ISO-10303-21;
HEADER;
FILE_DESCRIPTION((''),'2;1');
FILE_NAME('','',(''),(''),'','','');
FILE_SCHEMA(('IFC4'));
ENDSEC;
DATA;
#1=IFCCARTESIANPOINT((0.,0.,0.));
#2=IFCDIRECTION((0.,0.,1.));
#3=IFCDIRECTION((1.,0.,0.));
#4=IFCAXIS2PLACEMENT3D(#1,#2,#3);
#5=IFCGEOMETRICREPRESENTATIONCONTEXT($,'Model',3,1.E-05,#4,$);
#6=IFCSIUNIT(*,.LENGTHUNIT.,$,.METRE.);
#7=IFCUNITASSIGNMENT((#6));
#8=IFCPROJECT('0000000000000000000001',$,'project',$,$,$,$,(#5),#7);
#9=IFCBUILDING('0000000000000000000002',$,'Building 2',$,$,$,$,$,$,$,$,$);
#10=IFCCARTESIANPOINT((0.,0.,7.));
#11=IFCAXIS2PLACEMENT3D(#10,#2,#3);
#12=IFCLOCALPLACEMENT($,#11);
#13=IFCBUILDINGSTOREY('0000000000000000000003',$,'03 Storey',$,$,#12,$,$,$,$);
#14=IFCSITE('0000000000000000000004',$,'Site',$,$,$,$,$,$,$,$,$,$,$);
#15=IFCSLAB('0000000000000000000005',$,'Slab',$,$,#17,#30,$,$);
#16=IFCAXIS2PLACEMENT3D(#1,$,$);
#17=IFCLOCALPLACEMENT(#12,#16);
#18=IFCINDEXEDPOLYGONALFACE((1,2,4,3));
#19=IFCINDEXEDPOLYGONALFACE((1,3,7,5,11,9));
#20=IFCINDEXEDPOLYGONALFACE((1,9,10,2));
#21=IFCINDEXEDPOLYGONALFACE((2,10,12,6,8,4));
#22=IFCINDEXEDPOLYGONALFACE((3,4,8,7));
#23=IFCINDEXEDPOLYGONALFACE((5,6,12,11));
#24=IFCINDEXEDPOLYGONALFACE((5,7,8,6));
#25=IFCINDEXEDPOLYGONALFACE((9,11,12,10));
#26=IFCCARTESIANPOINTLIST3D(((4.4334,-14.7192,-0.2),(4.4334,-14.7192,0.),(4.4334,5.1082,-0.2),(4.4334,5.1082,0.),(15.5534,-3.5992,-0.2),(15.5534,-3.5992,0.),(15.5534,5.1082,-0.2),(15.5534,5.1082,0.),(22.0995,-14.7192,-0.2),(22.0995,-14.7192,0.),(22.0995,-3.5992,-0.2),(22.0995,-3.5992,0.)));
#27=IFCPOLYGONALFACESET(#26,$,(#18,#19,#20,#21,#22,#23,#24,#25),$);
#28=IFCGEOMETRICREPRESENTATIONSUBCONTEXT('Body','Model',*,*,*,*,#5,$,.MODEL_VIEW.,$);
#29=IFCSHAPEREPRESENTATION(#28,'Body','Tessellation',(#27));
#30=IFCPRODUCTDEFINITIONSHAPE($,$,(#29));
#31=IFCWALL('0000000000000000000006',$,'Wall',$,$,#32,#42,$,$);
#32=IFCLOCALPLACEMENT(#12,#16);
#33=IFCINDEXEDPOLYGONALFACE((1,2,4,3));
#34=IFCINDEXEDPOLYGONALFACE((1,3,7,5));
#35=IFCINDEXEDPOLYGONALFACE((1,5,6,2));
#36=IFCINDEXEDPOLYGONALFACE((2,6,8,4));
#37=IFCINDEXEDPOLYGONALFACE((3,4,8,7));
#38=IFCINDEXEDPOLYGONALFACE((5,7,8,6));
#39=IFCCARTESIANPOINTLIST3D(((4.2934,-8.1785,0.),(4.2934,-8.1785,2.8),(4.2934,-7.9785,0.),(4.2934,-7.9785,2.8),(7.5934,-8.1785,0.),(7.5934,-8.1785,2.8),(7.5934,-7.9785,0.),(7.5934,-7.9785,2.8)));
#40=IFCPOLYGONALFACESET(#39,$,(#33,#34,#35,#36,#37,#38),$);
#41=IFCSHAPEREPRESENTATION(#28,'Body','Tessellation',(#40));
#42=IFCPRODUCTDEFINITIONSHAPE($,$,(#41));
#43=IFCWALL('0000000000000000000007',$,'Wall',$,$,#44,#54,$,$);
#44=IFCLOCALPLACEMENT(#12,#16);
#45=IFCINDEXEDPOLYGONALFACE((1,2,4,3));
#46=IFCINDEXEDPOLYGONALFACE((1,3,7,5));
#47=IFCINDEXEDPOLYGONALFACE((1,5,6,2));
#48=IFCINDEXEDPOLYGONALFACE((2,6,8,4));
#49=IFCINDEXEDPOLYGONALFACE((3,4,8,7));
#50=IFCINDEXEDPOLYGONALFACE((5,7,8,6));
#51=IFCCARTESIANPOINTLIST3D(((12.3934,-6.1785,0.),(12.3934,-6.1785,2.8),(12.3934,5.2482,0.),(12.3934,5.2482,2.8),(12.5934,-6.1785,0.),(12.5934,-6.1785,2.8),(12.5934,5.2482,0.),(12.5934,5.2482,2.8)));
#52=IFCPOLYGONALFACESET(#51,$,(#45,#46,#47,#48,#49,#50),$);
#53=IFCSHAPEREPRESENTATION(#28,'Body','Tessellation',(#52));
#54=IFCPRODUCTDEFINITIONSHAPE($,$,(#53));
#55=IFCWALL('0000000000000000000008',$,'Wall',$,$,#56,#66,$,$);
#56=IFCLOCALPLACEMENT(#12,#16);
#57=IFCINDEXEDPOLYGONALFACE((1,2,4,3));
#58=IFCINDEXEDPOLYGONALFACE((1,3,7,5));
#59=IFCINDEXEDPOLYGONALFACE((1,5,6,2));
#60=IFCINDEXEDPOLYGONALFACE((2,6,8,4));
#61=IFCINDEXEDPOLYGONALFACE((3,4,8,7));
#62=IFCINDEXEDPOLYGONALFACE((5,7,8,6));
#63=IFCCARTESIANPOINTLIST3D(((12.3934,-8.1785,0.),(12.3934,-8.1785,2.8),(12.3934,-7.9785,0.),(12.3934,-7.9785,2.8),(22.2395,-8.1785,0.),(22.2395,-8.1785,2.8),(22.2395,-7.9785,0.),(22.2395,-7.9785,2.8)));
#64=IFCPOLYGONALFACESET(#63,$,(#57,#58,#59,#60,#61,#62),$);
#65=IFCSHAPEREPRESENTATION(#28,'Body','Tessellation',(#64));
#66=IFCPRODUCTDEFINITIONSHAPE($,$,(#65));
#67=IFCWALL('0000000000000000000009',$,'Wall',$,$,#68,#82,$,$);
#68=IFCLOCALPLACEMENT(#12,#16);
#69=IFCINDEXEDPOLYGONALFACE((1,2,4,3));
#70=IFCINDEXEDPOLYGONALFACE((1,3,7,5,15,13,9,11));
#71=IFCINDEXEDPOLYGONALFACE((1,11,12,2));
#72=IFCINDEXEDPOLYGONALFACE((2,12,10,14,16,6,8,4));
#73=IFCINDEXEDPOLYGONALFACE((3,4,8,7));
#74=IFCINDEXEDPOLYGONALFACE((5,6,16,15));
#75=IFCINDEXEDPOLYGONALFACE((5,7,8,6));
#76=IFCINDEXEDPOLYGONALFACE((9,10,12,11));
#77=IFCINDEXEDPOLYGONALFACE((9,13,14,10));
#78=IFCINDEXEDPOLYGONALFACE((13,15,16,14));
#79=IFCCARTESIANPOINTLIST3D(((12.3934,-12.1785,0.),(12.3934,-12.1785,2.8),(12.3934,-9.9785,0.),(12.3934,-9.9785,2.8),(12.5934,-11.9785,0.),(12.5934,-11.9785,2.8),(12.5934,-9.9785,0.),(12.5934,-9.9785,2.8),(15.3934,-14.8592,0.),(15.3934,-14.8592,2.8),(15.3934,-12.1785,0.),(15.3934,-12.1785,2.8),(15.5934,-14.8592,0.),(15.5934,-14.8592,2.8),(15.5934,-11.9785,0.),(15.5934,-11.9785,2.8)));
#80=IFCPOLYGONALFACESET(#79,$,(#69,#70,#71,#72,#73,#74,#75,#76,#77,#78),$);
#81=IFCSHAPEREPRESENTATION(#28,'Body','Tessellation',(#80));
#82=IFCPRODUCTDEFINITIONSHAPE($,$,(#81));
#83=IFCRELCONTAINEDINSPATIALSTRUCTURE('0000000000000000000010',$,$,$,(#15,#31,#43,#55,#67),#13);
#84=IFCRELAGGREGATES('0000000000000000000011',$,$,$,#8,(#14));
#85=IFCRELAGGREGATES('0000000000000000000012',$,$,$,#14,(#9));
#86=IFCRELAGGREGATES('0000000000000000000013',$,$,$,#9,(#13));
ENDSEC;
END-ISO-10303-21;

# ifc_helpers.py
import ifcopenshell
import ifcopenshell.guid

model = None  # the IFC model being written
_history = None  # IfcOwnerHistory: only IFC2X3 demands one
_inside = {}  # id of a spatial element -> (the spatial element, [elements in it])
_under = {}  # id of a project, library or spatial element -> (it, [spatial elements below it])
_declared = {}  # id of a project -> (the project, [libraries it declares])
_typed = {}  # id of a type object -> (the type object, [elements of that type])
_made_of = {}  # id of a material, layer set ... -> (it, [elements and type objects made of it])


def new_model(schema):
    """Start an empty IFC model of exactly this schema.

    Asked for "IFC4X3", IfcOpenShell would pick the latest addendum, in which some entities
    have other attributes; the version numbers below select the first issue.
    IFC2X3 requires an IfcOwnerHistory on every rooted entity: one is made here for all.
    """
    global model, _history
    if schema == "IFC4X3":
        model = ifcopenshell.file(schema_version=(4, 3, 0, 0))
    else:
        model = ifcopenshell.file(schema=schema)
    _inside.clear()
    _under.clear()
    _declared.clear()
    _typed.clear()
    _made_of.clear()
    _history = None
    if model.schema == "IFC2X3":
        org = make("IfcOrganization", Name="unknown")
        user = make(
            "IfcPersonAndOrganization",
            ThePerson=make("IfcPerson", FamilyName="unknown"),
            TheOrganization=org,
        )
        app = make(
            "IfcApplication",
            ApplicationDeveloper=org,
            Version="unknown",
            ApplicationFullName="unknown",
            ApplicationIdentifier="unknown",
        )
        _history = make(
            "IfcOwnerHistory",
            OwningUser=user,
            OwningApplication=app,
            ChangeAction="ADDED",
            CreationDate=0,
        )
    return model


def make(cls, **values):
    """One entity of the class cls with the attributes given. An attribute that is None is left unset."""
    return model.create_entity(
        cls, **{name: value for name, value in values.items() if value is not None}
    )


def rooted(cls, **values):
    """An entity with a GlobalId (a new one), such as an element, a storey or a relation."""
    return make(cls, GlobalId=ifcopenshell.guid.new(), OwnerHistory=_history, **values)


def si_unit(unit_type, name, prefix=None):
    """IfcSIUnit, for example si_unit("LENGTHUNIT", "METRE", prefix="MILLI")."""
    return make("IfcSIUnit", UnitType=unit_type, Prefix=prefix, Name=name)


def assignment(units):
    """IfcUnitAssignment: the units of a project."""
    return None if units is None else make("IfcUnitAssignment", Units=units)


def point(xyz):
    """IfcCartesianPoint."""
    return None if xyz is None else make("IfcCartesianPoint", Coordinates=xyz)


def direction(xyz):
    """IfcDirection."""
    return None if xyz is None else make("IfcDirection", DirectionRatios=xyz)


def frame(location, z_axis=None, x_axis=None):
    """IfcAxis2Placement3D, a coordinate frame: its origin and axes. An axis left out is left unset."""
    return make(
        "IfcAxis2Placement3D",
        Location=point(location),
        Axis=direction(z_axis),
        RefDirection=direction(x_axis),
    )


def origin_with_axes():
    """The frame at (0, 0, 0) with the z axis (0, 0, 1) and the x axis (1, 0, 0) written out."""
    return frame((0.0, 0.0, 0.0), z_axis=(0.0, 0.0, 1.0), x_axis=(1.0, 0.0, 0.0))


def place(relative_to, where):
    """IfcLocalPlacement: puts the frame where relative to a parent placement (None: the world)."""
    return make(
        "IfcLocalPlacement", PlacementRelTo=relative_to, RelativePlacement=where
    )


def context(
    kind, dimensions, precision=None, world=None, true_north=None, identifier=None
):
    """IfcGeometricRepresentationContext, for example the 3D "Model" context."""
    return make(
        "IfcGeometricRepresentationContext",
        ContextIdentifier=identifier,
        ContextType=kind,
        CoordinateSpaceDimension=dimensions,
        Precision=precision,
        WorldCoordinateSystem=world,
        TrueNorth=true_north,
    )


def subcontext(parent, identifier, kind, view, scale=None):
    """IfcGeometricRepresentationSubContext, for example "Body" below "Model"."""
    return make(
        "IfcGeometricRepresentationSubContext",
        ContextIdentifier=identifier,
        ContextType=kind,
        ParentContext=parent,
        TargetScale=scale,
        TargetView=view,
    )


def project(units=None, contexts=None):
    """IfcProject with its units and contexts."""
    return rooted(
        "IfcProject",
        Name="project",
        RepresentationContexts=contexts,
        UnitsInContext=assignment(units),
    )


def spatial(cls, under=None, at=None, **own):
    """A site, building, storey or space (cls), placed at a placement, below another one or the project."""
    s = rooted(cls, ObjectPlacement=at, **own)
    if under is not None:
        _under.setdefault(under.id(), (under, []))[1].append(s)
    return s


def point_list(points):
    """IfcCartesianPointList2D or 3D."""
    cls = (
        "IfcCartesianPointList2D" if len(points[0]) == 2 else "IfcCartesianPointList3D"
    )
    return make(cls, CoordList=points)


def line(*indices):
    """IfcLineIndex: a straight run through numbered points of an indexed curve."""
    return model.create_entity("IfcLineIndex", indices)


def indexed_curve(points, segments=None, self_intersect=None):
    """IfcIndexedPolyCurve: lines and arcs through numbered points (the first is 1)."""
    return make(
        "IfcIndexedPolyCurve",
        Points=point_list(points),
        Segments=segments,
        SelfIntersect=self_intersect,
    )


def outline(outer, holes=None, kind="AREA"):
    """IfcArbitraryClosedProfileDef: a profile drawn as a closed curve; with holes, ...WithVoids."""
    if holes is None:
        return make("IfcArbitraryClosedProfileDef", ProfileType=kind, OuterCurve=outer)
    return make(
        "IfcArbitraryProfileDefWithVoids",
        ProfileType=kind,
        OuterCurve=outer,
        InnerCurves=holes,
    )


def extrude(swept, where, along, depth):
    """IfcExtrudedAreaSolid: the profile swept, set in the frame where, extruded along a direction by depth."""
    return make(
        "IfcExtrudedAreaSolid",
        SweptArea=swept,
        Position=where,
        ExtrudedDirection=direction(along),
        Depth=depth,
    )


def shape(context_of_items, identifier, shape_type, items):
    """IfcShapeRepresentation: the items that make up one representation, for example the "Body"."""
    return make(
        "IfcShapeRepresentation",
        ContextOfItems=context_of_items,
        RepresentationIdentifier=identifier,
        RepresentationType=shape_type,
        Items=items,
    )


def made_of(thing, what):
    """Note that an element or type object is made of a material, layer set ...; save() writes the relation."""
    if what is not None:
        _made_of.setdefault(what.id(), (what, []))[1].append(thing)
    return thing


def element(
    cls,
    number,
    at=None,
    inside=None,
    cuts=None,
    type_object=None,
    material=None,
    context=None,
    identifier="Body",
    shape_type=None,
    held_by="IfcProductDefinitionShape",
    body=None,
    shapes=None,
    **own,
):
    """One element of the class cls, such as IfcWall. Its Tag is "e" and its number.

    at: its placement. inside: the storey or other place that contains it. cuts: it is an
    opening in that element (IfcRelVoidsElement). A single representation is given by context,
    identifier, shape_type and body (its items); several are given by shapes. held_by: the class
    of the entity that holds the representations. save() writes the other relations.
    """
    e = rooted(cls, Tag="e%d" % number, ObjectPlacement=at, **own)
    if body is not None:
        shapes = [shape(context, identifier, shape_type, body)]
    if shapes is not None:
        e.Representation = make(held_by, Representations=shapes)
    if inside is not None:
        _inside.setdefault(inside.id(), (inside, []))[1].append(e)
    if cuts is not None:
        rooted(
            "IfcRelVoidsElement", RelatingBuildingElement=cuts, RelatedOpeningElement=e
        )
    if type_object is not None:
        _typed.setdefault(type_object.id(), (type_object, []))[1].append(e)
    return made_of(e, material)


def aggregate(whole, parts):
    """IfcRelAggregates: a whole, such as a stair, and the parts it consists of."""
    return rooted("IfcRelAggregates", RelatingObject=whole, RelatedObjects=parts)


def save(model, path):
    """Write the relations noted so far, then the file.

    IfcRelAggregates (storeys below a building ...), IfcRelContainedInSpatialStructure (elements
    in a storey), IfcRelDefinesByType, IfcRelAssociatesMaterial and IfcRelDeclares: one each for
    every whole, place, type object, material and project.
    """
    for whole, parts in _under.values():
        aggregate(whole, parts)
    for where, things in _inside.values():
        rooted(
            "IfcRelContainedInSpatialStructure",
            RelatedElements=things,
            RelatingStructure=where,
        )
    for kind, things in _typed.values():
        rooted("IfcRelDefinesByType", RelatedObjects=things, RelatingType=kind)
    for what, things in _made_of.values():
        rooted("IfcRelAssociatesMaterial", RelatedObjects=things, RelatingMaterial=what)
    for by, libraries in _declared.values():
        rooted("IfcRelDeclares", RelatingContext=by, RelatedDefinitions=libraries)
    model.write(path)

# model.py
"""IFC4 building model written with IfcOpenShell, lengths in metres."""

from ifc_helpers import new_model, si_unit, frame, origin_with_axes, place, context, subcontext, project, spatial, line, indexed_curve, outline, extrude, element, save


model = new_model("IFC4")

# Units and contexts
model_context = context("Model", 3, precision=1e-05, world=origin_with_axes())
body_context = subcontext(model_context, "Body", "Model", "MODEL_VIEW")
ifc_project = project(units=[si_unit("LENGTHUNIT", "METRE")], contexts=[model_context])

# Site, building, storey
site = spatial("IfcSite", under=ifc_project, Name="Site")
building = spatial("IfcBuilding", under=site, Name="Building 2")
storey_placement = place(None, frame((0.0, 0.0, 7.0), z_axis=(0.0, 0.0, 1.0), x_axis=(1.0, 0.0, 0.0)))
storey = spatial("IfcBuildingStorey", under=building, at=storey_placement, Name="03 Storey")

# Slab
slab_placement = place(storey_placement, origin_with_axes())
element("IfcSlab", 1, at=slab_placement, inside=storey, Name="Slab", context=body_context, shape_type="SweptSolid", body=[
    extrude(outline(indexed_curve([(22.0995, -3.5992), (15.5534, -3.5992), (15.5534, 5.1082), (4.4334, 5.1082), (4.4334, -14.7192), (22.0995, -14.7192)], segments=[line(1, 2), line(2, 3), line(3, 4), line(4, 5), line(5, 6)])), origin_with_axes(), (0.0, 0.0, -1.0), 0.2),
])

# Walls
wall_1_placement = place(storey_placement, origin_with_axes())
element("IfcWall", 2, at=wall_1_placement, inside=storey, Name="Wall", context=body_context, shape_type="SweptSolid", body=[
    extrude(outline(indexed_curve([(7.5934, -7.9785), (4.2934, -7.9785), (4.2934, -8.1785), (7.5934, -8.1785)], segments=[line(1, 2), line(2, 3), line(3, 4)])), origin_with_axes(), (0.0, 0.0, 1.0), 2.8),
])
wall_2_placement = place(storey_placement, origin_with_axes())
element("IfcWall", 3, at=wall_2_placement, inside=storey, Name="Wall", context=body_context, shape_type="SweptSolid", body=[
    extrude(outline(indexed_curve([(12.5934, 5.2482), (12.3934, 5.2482), (12.3934, -6.1785), (12.5934, -6.1785)], segments=[line(1, 2), line(2, 3), line(3, 4)])), origin_with_axes(), (0.0, 0.0, 1.0), 2.8),
])
wall_3_placement = place(storey_placement, origin_with_axes())
element("IfcWall", 4, at=wall_3_placement, inside=storey, Name="Wall", context=body_context, shape_type="SweptSolid", body=[
    extrude(outline(indexed_curve([(22.2395, -7.9785), (12.3934, -7.9785), (12.3934, -8.1785), (22.2395, -8.1785)], segments=[line(1, 2), line(2, 3), line(3, 4)])), origin_with_axes(), (0.0, 0.0, 1.0), 2.8),
])
wall_4_placement = place(storey_placement, origin_with_axes())
element("IfcWall", 5, at=wall_4_placement, inside=storey, Name="Wall", context=body_context, shape_type="SweptSolid", body=[
    extrude(outline(indexed_curve([(15.5934, -11.9785), (12.5934, -11.9785), (12.5934, -9.9785), (12.3934, -9.9785), (12.3934, -12.1785), (15.3934, -12.1785), (15.3934, -14.8592), (15.5934, -14.8592)], segments=[line(1, 2), line(2, 3), line(3, 4), line(4, 5), line(5, 6), line(6, 7), line(7, 8)])), origin_with_axes(), (0.0, 0.0, 1.0), 2.8),
])

save(model, "model.ifc")
